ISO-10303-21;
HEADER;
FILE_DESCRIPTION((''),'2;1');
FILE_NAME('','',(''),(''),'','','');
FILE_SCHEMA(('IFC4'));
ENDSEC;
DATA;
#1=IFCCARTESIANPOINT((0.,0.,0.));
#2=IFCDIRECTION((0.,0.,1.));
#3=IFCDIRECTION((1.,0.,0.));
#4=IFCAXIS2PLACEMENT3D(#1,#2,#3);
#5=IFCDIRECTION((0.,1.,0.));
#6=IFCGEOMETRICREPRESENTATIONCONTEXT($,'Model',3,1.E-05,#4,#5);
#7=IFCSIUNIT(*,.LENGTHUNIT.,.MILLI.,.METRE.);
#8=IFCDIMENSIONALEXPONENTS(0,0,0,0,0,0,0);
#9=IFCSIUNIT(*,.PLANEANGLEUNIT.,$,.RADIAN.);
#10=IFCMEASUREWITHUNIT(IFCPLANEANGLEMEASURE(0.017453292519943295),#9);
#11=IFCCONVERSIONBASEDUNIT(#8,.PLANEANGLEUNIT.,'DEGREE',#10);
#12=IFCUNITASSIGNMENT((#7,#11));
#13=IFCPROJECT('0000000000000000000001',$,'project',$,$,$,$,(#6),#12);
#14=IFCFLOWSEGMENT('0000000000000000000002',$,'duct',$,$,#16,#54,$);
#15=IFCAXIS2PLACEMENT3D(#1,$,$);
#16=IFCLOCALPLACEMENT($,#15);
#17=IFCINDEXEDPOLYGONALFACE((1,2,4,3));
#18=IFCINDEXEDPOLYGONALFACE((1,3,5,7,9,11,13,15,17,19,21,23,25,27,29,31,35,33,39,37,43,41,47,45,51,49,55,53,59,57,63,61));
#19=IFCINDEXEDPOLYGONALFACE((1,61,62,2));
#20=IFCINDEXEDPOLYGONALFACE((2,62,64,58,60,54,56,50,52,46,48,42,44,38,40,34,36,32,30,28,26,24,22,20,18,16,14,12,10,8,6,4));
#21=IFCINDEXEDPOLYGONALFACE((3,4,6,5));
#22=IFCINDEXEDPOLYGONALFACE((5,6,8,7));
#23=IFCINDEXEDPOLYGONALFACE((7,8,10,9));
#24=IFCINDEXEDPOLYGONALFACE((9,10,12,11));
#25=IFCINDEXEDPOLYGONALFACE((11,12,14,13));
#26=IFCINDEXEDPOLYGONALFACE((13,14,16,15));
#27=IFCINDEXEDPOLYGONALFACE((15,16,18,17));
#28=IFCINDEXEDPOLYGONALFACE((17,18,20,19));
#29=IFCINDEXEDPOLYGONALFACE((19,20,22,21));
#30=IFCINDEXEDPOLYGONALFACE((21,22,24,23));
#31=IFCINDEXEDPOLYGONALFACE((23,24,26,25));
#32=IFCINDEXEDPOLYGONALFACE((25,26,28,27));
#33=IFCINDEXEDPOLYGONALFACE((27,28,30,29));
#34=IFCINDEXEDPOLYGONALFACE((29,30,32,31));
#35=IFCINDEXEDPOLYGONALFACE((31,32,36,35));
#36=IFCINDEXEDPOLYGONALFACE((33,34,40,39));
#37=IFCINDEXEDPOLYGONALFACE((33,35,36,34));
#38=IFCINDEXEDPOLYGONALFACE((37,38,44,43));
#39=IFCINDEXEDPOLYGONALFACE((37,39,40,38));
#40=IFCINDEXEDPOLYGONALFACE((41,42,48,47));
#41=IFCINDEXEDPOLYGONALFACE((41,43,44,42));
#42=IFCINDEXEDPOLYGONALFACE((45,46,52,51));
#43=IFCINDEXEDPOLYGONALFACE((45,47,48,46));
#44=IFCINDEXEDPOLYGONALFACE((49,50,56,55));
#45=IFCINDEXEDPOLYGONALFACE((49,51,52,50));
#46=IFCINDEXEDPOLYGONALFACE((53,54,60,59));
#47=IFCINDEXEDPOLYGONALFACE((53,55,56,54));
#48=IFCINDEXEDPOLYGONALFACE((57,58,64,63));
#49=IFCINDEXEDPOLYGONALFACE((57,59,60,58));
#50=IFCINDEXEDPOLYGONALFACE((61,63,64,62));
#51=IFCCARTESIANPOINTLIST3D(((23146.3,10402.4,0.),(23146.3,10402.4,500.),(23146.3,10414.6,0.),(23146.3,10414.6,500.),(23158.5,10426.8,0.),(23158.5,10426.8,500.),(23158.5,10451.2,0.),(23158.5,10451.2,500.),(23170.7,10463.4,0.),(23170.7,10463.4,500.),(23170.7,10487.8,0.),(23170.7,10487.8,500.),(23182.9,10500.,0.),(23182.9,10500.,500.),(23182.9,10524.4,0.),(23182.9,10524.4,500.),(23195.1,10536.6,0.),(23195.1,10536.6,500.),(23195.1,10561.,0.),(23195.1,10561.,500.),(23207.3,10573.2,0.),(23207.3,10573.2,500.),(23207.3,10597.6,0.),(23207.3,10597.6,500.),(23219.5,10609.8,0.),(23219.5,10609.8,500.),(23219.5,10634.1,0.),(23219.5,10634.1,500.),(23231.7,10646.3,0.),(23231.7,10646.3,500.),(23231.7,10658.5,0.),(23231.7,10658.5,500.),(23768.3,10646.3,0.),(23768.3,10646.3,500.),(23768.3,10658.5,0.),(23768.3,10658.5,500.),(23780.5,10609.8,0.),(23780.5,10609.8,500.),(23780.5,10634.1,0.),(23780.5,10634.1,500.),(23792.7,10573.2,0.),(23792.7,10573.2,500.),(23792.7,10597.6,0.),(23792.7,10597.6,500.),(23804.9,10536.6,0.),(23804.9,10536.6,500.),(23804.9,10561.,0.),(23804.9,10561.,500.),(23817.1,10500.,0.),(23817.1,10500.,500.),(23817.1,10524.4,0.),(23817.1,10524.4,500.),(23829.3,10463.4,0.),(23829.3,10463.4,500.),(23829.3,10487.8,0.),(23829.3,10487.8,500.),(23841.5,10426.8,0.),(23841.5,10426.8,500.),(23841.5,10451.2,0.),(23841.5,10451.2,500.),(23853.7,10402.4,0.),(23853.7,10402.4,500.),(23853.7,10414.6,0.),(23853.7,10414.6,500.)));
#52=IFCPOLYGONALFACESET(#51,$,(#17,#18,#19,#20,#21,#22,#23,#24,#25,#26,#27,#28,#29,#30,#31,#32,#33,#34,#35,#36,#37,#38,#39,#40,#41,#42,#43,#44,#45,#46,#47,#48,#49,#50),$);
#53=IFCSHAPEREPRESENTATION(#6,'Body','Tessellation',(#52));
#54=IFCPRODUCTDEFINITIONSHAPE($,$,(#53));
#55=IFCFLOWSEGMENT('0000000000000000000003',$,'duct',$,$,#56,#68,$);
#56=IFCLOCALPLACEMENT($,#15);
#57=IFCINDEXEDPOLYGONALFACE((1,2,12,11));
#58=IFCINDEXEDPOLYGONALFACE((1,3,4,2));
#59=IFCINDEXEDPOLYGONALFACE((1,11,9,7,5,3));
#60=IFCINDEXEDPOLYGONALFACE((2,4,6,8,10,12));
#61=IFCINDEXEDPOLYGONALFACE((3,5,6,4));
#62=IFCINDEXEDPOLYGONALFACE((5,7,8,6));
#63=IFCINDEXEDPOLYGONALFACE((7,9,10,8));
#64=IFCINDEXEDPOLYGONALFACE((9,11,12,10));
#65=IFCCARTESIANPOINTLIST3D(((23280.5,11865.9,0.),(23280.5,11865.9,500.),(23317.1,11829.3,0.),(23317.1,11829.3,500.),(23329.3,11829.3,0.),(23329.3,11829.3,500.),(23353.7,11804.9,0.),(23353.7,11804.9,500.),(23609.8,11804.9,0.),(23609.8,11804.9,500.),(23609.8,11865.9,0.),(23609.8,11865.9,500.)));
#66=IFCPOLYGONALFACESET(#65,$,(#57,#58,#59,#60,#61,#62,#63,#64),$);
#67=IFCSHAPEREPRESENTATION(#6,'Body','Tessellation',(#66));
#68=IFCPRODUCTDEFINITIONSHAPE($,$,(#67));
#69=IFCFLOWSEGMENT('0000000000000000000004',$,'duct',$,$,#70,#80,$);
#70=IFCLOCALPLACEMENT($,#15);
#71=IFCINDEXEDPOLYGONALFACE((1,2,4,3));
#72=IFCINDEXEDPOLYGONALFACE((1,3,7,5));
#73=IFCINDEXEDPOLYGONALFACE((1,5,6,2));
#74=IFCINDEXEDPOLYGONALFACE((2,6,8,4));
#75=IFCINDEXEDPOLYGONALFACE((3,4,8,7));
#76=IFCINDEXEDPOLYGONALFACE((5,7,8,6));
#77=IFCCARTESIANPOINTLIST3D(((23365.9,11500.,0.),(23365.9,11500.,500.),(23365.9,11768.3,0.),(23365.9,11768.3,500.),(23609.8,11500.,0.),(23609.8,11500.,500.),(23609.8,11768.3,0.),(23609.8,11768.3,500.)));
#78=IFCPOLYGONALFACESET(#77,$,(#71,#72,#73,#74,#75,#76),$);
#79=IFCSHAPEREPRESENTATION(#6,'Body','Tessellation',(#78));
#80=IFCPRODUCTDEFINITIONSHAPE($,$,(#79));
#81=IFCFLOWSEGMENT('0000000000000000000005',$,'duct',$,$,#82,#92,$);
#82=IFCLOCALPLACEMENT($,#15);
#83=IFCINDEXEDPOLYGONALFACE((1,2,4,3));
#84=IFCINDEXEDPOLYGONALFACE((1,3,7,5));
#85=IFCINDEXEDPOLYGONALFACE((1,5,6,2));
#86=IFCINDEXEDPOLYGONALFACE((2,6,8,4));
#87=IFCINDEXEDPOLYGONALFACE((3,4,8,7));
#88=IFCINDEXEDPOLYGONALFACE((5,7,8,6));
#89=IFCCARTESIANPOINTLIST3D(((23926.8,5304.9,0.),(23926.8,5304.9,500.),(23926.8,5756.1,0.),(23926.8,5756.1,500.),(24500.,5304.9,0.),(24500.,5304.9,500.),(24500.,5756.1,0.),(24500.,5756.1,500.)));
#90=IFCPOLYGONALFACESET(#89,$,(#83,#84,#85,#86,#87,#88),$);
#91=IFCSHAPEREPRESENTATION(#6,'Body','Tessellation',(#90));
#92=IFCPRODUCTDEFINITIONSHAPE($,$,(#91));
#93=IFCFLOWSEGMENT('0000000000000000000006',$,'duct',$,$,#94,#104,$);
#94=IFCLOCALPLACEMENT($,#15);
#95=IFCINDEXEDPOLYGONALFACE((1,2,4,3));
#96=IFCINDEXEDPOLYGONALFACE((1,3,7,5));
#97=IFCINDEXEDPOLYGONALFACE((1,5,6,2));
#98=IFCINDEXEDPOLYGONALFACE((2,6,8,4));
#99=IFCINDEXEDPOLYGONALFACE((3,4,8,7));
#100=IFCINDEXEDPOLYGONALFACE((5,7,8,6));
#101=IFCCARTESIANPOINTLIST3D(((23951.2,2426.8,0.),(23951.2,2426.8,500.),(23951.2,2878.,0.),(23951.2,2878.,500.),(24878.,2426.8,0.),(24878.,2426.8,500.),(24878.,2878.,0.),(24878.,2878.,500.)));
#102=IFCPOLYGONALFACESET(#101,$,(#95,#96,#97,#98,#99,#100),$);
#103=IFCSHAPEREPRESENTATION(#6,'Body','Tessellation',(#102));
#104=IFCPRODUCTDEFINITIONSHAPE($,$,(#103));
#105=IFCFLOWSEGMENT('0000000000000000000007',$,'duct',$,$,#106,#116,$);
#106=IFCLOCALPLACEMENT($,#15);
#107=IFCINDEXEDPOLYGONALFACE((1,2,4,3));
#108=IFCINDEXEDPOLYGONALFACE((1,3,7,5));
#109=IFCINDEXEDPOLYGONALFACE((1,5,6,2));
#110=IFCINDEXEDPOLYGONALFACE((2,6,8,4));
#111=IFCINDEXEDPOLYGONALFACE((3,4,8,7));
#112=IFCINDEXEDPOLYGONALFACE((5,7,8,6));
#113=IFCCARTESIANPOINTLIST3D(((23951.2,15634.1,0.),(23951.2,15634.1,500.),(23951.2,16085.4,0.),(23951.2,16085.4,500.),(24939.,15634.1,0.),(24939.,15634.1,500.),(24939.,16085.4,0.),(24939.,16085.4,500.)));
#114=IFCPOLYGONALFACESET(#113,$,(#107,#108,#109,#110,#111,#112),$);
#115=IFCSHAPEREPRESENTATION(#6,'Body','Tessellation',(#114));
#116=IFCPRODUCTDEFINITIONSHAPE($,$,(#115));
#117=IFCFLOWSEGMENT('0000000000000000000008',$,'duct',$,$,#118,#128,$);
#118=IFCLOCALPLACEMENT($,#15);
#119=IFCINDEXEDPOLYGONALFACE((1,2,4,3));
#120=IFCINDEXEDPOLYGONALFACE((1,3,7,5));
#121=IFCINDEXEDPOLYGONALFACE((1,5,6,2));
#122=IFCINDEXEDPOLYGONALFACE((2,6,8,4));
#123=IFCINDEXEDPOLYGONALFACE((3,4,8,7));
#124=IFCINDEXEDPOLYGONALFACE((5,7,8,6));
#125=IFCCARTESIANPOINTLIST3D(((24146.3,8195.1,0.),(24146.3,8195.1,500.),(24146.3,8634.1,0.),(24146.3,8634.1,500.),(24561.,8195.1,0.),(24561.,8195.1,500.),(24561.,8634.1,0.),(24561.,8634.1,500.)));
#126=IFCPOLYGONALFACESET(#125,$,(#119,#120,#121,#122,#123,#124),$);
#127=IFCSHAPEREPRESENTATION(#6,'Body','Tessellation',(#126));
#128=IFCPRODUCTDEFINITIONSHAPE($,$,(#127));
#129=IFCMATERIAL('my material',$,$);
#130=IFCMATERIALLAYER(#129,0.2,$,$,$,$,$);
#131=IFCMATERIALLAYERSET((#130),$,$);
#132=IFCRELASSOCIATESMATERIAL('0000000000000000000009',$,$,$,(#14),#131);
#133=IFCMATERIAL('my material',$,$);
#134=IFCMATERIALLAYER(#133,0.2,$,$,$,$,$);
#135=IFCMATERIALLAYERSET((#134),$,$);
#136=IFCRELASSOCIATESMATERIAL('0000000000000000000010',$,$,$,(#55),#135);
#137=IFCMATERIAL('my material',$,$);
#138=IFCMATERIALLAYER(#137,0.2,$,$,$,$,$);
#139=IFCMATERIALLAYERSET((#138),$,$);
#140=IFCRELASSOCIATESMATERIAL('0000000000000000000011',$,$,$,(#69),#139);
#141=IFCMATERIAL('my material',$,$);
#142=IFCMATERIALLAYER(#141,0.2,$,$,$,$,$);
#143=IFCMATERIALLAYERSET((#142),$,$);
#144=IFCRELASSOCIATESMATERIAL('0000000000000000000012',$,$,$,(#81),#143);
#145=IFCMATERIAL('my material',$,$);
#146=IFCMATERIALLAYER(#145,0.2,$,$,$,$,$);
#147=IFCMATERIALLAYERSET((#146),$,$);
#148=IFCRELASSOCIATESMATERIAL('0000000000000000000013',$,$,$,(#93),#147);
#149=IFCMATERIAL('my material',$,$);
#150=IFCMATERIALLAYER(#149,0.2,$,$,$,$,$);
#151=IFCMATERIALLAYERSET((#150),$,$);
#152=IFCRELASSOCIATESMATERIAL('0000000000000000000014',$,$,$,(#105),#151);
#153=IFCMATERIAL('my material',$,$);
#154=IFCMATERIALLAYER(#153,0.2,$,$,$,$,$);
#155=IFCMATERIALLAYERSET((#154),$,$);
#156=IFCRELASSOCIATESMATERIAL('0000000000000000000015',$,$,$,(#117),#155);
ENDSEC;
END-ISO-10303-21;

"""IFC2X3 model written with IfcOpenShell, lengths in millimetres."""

from ifc_helpers import new_model, entity, si_unit, converted_unit, direction, origin_with_axes, place, context, project, polyline, outline, extrude, material, layer, layer_set, layer_usage, element, save


model = new_model("IFC2X3")

# Units and contexts
model_context = context("Model", 3, precision=1e-05, world=origin_with_axes(), true_north=direction((0.0, 1.0, 0.0)))
ifc_project = project(units=[si_unit("LENGTHUNIT", "METRE", prefix="MILLI"), converted_unit("PLANEANGLEUNIT", "DEGREE", entity("IfcPlaneAngleMeasure", 0.017453292519943295), si_unit("PLANEANGLEUNIT", "RADIAN"), dimensions=[0, 0, 0, 0, 0, 0, 0])], contexts=[model_context])

# Flow segments
ifc_material_1 = material(Name="my material")
ifc_layer_1 = layer(ifc_material_1, 0.2)
ifc_layer_set_1 = layer_set([ifc_layer_1])
ifc_layer_usage_1 = layer_usage(ifc_layer_set_1, "AXIS2", "POSITIVE", -0.1)
flow_segment_1_placement = place(None, origin_with_axes())
element("IfcFlowSegment", 1, at=flow_segment_1_placement, material=ifc_layer_usage_1, Name="duct", context=model_context, shape_type="SweptSolid", body=[
    extrude(outline(polyline([(23146.3, 10402.4), (23853.7, 10402.4), (23853.7, 10414.6), (23841.5, 10426.8), (23841.5, 10451.2), (23829.3, 10463.4), (23829.3, 10487.8), (23817.1, 10500.0), (23817.1, 10524.4), (23804.9, 10536.6), (23804.9, 10561.0), (23792.7, 10573.2), (23792.7, 10597.6), (23780.5, 10609.8), (23780.5, 10634.1), (23768.3, 10646.3), (23768.3, 10658.5), (23231.7, 10658.5), (23231.7, 10646.3), (23219.5, 10634.1), (23219.5, 10609.8), (23207.3, 10597.6), (23207.3, 10573.2), (23195.1, 10561.0), (23195.1, 10536.6), (23182.9, 10524.4), (23182.9, 10500.0), (23170.7, 10487.8), (23170.7, 10463.4), (23158.5, 10451.2), (23158.5, 10426.8), (23146.3, 10414.6), (23146.3, 10402.4)])), origin_with_axes(), (0.0, 0.0, 1.0), 500.0),
])
ifc_material_2 = material(Name="my material")
ifc_layer_2 = layer(ifc_material_2, 0.2)
ifc_layer_set_2 = layer_set([ifc_layer_2])
ifc_layer_usage_2 = layer_usage(ifc_layer_set_2, "AXIS2", "POSITIVE", -0.1)
flow_segment_2_placement = place(None, origin_with_axes())
element("IfcFlowSegment", 2, at=flow_segment_2_placement, material=ifc_layer_usage_2, Name="duct", context=model_context, shape_type="SweptSolid", body=[
    extrude(outline(polyline([(23268.3, 11865.9), (23280.5, 11865.9), (23317.1, 11829.3), (23329.3, 11829.3), (23353.7, 11804.9), (23609.8, 11804.9), (23609.8, 11865.9), (23268.3, 11865.9)])), origin_with_axes(), (0.0, 0.0, 1.0), 500.0),
])
ifc_material_3 = material(Name="my material")
ifc_layer_3 = layer(ifc_material_3, 0.2)
ifc_layer_set_3 = layer_set([ifc_layer_3])
ifc_layer_usage_3 = layer_usage(ifc_layer_set_3, "AXIS2", "POSITIVE", -0.1)
flow_segment_3_placement = place(None, origin_with_axes())
element("IfcFlowSegment", 3, at=flow_segment_3_placement, material=ifc_layer_usage_3, Name="duct", context=model_context, shape_type="SweptSolid", body=[
    extrude(outline(polyline([(23365.9, 11500.0), (23609.8, 11500.0), (23609.8, 11768.3), (23365.9, 11768.3), (23365.9, 11500.0)])), origin_with_axes(), (0.0, 0.0, 1.0), 500.0),
])
ifc_material_4 = material(Name="my material")
ifc_layer_4 = layer(ifc_material_4, 0.2)
ifc_layer_set_4 = layer_set([ifc_layer_4])
ifc_layer_usage_4 = layer_usage(ifc_layer_set_4, "AXIS2", "POSITIVE", -0.1)
flow_segment_4_placement = place(None, origin_with_axes())
element("IfcFlowSegment", 4, at=flow_segment_4_placement, material=ifc_layer_usage_4, Name="duct", context=model_context, shape_type="SweptSolid", body=[
    extrude(outline(polyline([(23926.8, 5304.9), (24500.0, 5304.9), (24500.0, 5756.1), (23926.8, 5756.1), (23926.8, 5304.9)])), origin_with_axes(), (0.0, 0.0, 1.0), 500.0),
])
ifc_material_5 = material(Name="my material")
ifc_layer_5 = layer(ifc_material_5, 0.2)
ifc_layer_set_5 = layer_set([ifc_layer_5])
ifc_layer_usage_5 = layer_usage(ifc_layer_set_5, "AXIS2", "POSITIVE", -0.1)
flow_segment_5_placement = place(None, origin_with_axes())
element("IfcFlowSegment", 5, at=flow_segment_5_placement, material=ifc_layer_usage_5, Name="duct", context=model_context, shape_type="SweptSolid", body=[
    extrude(outline(polyline([(23951.2, 2426.8), (24878.0, 2426.8), (24878.0, 2878.0), (23951.2, 2878.0), (23951.2, 2426.8)])), origin_with_axes(), (0.0, 0.0, 1.0), 500.0),
])
ifc_material_6 = material(Name="my material")
ifc_layer_6 = layer(ifc_material_6, 0.2)
ifc_layer_set_6 = layer_set([ifc_layer_6])
ifc_layer_usage_6 = layer_usage(ifc_layer_set_6, "AXIS2", "POSITIVE", -0.1)
flow_segment_6_placement = place(None, origin_with_axes())
element("IfcFlowSegment", 6, at=flow_segment_6_placement, material=ifc_layer_usage_6, Name="duct", context=model_context, shape_type="SweptSolid", body=[
    extrude(outline(polyline([(23951.2, 15634.1), (24939.0, 15634.1), (24939.0, 16085.4), (23951.2, 16085.4), (23951.2, 15634.1)])), origin_with_axes(), (0.0, 0.0, 1.0), 500.0),
])
ifc_material_7 = material(Name="my material")
ifc_layer_7 = layer(ifc_material_7, 0.2)
ifc_layer_set_7 = layer_set([ifc_layer_7])
ifc_layer_usage_7 = layer_usage(ifc_layer_set_7, "AXIS2", "POSITIVE", -0.1)
flow_segment_7_placement = place(None, origin_with_axes())
element("IfcFlowSegment", 7, at=flow_segment_7_placement, material=ifc_layer_usage_7, Name="duct", context=model_context, shape_type="SweptSolid", body=[
    extrude(outline(polyline([(24146.3, 8195.1), (24561.0, 8195.1), (24561.0, 8634.1), (24146.3, 8634.1), (24146.3, 8195.1)])), origin_with_axes(), (0.0, 0.0, 1.0), 500.0),
])

save(model, "model.ifc")
